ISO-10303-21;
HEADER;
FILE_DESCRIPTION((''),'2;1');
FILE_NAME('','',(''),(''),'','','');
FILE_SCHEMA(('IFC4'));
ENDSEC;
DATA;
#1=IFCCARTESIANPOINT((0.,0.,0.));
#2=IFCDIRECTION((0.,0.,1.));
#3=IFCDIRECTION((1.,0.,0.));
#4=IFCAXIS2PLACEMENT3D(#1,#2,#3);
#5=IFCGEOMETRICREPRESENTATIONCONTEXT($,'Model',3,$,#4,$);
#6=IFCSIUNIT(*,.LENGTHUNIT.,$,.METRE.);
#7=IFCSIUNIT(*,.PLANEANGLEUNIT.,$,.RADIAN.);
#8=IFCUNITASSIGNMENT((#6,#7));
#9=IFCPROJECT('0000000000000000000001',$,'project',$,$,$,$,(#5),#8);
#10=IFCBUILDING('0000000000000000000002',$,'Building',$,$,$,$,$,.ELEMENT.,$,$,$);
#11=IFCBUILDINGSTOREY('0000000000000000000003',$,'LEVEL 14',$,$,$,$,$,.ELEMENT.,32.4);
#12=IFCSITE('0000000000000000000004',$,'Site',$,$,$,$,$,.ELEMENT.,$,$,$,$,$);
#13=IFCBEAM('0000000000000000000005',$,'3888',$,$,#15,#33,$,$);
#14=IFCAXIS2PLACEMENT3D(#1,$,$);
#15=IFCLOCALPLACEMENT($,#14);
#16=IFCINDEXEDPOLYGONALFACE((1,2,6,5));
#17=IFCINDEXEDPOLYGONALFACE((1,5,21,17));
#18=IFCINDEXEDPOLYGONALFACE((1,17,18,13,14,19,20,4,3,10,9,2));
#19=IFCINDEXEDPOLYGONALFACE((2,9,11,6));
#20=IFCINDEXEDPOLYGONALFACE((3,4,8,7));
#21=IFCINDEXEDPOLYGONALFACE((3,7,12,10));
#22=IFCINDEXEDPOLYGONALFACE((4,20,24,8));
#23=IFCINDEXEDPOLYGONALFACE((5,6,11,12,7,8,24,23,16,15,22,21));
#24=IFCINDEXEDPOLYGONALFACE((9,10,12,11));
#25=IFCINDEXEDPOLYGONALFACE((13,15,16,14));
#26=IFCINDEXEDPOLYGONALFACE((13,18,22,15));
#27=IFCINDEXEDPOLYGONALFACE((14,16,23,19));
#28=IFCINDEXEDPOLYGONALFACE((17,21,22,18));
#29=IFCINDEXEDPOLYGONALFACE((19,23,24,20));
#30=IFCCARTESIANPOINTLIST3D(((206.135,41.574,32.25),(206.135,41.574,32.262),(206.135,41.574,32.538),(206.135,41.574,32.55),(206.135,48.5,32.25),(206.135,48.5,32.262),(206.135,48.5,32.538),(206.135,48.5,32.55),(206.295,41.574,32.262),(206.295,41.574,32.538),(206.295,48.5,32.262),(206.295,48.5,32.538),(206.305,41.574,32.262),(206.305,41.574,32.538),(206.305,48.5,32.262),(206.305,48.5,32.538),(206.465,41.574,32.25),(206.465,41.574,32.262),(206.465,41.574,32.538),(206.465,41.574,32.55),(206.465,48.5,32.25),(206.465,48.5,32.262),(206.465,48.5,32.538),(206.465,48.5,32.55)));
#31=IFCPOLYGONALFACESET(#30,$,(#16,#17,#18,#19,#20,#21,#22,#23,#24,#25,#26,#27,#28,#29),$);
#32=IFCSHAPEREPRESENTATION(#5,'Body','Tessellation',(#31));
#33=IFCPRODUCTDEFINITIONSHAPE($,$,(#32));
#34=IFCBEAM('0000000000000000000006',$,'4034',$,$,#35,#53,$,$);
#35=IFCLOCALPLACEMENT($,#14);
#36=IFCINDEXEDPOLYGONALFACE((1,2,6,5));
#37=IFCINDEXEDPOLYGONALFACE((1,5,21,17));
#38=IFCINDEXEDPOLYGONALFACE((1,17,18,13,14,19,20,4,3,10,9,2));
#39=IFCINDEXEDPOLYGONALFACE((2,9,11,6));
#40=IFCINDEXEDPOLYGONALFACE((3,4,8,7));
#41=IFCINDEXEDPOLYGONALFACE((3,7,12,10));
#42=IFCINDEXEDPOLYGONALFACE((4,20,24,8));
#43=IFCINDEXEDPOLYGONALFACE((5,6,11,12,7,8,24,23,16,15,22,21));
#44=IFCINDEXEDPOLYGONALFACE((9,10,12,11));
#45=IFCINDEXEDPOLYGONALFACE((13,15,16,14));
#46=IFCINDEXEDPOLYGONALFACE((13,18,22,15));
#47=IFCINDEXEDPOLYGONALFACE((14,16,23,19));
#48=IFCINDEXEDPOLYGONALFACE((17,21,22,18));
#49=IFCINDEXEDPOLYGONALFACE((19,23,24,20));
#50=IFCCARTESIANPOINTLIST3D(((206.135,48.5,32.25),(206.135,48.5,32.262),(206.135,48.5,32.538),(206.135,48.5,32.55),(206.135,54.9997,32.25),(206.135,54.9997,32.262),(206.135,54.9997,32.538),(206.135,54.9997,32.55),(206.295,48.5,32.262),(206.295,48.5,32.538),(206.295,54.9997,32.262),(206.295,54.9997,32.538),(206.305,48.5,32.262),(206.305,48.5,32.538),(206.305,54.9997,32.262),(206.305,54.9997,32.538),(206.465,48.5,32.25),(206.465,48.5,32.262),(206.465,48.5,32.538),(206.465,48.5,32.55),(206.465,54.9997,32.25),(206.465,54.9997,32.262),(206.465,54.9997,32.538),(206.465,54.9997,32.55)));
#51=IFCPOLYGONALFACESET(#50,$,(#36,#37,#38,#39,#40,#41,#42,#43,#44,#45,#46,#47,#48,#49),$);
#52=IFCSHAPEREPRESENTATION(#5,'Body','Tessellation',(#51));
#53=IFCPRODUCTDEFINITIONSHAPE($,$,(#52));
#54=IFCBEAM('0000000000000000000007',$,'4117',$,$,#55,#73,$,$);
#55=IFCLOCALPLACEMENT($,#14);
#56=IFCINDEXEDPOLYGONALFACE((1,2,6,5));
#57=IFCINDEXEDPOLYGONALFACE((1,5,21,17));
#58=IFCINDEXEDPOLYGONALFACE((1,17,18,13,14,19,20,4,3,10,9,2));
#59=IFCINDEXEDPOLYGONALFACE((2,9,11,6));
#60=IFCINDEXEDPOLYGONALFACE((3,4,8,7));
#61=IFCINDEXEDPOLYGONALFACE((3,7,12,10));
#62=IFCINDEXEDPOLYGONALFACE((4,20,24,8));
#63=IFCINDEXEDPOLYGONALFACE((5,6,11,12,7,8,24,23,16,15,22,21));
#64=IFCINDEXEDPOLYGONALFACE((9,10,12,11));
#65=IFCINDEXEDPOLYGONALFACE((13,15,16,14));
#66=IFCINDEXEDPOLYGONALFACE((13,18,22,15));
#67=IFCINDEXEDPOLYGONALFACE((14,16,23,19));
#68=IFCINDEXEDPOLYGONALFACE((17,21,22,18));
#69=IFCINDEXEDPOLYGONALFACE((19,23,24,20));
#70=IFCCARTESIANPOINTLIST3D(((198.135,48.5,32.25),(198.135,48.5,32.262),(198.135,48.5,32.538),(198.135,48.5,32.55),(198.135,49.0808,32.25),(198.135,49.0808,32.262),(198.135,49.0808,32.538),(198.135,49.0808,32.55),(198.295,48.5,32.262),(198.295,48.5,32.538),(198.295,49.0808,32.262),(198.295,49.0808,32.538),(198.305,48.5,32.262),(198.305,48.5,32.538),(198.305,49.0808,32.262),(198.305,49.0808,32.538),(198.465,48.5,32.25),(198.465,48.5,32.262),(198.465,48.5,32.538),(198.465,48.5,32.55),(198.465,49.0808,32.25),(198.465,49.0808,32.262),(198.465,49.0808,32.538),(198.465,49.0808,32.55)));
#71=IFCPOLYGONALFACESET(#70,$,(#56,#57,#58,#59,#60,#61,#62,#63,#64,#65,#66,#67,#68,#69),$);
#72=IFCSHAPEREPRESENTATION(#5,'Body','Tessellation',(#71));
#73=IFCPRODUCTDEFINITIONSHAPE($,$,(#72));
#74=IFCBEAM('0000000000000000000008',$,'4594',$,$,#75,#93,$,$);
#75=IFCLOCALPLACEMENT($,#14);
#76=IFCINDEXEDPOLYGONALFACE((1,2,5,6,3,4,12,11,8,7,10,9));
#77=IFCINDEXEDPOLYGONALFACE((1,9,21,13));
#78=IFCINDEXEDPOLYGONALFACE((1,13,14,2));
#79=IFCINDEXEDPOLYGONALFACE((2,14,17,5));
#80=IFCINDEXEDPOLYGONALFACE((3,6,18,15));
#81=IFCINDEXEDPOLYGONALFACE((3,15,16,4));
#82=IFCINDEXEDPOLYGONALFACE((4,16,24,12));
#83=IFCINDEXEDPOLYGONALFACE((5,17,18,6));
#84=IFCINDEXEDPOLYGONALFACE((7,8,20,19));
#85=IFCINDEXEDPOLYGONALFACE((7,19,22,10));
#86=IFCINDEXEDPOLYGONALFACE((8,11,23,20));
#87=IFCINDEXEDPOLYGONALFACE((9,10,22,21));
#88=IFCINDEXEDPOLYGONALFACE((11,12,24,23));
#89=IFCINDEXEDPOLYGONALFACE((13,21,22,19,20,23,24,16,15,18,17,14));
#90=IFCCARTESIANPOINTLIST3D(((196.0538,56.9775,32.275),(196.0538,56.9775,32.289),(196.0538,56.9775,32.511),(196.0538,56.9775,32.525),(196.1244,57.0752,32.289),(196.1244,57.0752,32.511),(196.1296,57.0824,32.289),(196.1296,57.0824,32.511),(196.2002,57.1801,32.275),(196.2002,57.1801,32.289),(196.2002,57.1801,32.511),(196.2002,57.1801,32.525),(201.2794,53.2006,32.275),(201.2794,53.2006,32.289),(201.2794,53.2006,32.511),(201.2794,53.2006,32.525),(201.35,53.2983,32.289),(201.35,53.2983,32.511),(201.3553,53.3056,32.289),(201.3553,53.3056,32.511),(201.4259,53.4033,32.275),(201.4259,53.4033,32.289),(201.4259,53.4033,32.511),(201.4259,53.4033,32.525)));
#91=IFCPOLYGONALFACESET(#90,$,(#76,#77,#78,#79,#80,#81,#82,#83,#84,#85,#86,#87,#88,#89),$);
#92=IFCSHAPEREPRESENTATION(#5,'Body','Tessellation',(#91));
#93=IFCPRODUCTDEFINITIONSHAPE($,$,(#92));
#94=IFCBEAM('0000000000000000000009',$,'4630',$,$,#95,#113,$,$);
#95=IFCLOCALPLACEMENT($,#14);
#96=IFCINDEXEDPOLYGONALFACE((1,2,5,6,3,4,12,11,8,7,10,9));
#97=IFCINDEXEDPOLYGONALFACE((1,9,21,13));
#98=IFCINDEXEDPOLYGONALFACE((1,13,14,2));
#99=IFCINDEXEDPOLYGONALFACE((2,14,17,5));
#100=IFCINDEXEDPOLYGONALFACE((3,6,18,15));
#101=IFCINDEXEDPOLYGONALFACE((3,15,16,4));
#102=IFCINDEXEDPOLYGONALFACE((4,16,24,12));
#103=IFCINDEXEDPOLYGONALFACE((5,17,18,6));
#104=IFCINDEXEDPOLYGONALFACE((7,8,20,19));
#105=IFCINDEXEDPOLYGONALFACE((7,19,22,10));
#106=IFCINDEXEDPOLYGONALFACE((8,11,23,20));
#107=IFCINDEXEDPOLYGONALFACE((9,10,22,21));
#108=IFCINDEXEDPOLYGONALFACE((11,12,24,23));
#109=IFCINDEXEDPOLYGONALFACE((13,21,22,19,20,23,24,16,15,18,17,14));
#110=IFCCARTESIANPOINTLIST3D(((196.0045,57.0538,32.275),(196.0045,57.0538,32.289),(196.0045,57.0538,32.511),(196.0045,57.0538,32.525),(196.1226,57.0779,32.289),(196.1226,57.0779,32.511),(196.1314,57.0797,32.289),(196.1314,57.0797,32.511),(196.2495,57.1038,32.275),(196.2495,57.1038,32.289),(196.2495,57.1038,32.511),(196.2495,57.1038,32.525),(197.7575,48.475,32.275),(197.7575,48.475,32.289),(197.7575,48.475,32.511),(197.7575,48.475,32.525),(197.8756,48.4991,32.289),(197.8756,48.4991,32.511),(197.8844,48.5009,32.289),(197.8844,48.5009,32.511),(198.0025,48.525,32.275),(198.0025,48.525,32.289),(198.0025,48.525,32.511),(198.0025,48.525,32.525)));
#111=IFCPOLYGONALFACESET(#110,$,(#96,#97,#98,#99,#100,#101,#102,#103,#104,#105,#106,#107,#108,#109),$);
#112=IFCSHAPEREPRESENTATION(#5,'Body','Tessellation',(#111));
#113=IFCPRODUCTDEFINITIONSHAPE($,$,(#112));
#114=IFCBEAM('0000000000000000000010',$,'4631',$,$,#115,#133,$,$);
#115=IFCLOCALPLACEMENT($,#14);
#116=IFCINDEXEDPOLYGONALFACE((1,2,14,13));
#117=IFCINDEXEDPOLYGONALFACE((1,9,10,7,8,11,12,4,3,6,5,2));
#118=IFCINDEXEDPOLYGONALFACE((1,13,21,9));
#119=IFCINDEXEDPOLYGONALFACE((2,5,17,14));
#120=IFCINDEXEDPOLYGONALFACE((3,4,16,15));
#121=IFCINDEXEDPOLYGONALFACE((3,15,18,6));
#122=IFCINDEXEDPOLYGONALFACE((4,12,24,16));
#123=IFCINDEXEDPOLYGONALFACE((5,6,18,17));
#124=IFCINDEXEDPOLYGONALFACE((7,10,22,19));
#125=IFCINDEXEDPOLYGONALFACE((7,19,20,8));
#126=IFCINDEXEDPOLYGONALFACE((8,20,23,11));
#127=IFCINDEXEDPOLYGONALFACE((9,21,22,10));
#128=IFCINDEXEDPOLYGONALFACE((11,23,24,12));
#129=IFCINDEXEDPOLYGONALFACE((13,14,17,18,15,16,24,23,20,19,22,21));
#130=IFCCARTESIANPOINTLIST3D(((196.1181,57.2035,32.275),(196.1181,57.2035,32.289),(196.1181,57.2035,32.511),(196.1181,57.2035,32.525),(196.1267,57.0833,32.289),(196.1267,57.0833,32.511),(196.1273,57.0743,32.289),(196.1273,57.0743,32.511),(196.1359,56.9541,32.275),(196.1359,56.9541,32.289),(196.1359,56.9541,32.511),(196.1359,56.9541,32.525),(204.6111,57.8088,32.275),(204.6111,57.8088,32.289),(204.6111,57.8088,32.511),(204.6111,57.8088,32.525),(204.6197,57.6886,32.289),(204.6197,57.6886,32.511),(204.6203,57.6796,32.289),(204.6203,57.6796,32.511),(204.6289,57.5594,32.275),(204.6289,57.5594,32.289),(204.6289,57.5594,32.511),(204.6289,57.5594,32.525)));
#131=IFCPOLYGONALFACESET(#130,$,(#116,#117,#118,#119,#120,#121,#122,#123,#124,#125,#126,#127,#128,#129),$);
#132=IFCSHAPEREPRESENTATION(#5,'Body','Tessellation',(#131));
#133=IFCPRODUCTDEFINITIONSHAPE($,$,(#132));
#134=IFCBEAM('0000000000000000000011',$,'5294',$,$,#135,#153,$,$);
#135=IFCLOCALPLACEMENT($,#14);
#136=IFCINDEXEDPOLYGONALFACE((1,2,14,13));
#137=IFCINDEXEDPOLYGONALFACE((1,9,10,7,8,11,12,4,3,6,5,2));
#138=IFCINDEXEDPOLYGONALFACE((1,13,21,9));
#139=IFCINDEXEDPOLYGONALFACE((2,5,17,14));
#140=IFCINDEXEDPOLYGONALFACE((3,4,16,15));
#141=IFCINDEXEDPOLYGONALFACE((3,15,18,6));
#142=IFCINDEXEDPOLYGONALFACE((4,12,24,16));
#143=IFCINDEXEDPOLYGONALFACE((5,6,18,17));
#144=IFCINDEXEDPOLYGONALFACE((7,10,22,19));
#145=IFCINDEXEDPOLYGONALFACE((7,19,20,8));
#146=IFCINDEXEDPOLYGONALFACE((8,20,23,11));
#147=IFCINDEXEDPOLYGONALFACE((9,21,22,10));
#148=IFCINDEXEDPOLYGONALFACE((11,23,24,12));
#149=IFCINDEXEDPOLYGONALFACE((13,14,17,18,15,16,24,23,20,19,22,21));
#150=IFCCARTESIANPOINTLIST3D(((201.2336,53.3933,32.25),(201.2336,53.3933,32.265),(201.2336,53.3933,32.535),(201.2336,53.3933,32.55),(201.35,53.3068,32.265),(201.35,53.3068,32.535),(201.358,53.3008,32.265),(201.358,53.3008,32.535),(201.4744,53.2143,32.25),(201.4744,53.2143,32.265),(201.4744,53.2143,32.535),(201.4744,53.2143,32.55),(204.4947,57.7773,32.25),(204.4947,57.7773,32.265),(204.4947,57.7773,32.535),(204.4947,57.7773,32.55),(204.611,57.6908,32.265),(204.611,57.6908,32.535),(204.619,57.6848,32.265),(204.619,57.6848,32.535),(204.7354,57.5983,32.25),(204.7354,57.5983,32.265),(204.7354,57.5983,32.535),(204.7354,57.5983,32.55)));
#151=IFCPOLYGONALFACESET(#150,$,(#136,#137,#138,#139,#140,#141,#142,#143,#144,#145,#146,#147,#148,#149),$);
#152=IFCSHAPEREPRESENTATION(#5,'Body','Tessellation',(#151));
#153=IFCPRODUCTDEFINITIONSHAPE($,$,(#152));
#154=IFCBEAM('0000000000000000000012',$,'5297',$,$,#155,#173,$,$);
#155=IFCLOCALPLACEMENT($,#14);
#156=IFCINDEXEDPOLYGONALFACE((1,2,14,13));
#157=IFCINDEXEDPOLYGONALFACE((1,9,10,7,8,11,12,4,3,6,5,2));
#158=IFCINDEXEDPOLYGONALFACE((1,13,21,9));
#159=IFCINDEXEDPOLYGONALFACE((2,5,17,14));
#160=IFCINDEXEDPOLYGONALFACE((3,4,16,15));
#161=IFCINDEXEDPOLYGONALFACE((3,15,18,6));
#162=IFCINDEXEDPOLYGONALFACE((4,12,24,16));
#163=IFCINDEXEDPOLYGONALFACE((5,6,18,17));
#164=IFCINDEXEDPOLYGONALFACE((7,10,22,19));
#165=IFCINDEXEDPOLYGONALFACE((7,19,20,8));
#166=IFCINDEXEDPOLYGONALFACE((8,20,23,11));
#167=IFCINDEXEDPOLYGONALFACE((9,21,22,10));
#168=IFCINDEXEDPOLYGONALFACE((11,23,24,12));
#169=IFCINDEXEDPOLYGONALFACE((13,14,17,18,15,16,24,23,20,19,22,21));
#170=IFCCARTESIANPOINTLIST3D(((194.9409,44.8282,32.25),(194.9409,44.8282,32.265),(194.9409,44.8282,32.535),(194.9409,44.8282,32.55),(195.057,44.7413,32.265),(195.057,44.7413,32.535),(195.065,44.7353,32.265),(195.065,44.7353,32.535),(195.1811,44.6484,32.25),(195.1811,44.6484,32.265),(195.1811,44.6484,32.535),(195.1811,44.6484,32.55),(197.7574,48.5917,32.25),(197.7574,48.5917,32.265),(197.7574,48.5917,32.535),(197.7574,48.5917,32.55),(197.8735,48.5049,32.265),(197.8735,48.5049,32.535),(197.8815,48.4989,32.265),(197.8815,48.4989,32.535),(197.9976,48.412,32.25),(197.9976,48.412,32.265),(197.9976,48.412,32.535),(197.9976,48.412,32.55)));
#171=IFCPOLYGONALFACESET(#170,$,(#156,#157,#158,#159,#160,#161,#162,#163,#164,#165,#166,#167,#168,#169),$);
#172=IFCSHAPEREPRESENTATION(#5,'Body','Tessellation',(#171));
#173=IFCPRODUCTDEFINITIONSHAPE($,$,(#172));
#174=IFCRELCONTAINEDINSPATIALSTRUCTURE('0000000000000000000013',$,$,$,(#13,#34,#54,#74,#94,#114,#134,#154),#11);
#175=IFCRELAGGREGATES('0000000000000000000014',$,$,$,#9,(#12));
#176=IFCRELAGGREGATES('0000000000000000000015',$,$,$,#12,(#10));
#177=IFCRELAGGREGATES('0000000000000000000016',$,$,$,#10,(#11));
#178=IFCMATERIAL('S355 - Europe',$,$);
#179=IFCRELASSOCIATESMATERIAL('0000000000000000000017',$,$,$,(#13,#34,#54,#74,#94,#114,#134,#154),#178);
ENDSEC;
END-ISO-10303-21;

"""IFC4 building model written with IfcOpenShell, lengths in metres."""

from ifc_helpers import new_model, si_unit, frame, origin_with_axes, origin_2d_with_axis, place, context, project, spatial, i_section, extrude, material, material_profile, profile_set, profile_usage, element, save


model = new_model("IFC4")

# Units and contexts
model_context = context("Model", 3, world=origin_with_axes())
ifc_project = project(units=[si_unit("LENGTHUNIT", "METRE"), si_unit("PLANEANGLEUNIT", "RADIAN")], contexts=[model_context])

# Site, building, storey
site = spatial("IfcSite", under=ifc_project, Name="Site", CompositionType="ELEMENT")
building = spatial("IfcBuilding", under=site, Name="Building", CompositionType="ELEMENT")
storey = spatial("IfcBuildingStorey", under=building, Name="LEVEL 14", CompositionType="ELEMENT", Elevation=32.4)

# Shared definitions
ifc_material = material(Name="S355 - Europe")

# Beams
ifc_material_profile_1 = material_profile(ifc_material, i_section(OverallWidth=0.33, OverallDepth=0.3, WebThickness=0.01, FlangeThickness=0.012, at=origin_2d_with_axis()))
ifc_profile_set_1 = profile_set([ifc_material_profile_1])
ifc_profile_usage_1 = profile_usage(ifc_profile_set_1, cardinal=10)
beam_1_placement = place(None, frame((206.3, 48.5, 32.4), z_axis=(0.0, -1.0, 0.0), x_axis=(1.0, 0.0, 0.0)))
element("IfcBeam", 1, at=beam_1_placement, inside=storey, material=ifc_profile_usage_1, Name="3888", context=model_context, shape_type="SweptSolid", body=[
    extrude(i_section(OverallWidth=0.33, OverallDepth=0.3, WebThickness=0.01, FlangeThickness=0.012, at=origin_2d_with_axis()), origin_with_axes(), (0.0, 0.0, 1.0), 6.926),
])
ifc_material_profile_2 = material_profile(ifc_material, i_section(OverallWidth=0.33, OverallDepth=0.3, WebThickness=0.01, FlangeThickness=0.012, at=origin_2d_with_axis()))
ifc_profile_set_2 = profile_set([ifc_material_profile_2])
ifc_profile_usage_2 = profile_usage(ifc_profile_set_2, cardinal=10)
beam_2_placement = place(None, frame((206.3, 54.9997, 32.4), z_axis=(0.0, -1.0, 0.0), x_axis=(1.0, 0.0, 0.0)))
element("IfcBeam", 2, at=beam_2_placement, inside=storey, material=ifc_profile_usage_2, Name="4034", context=model_context, shape_type="SweptSolid", body=[
    extrude(i_section(OverallWidth=0.33, OverallDepth=0.3, WebThickness=0.01, FlangeThickness=0.012, at=origin_2d_with_axis()), origin_with_axes(), (0.0, 0.0, 1.0), 6.4997),
])
ifc_material_profile_3 = material_profile(ifc_material, i_section(OverallWidth=0.33, OverallDepth=0.3, WebThickness=0.01, FlangeThickness=0.012, at=origin_2d_with_axis()))
ifc_profile_set_3 = profile_set([ifc_material_profile_3])
ifc_profile_usage_3 = profile_usage(ifc_profile_set_3, cardinal=10)
beam_3_placement = place(None, frame((198.3, 48.5, 32.4), z_axis=(0.0, 1.0, 0.0), x_axis=(-1.0, 0.0, 0.0)))
element("IfcBeam", 3, at=beam_3_placement, inside=storey, material=ifc_profile_usage_3, Name="4117", context=model_context, shape_type="SweptSolid", body=[
    extrude(i_section(OverallWidth=0.33, OverallDepth=0.3, WebThickness=0.01, FlangeThickness=0.012, at=origin_2d_with_axis()), origin_with_axes(), (0.0, 0.0, 1.0), 0.5808),
])
ifc_material_profile_4 = material_profile(ifc_material, i_section(OverallWidth=0.25, OverallDepth=0.25, WebThickness=0.009, FlangeThickness=0.014, at=origin_2d_with_axis()))
ifc_profile_set_4 = profile_set([ifc_material_profile_4])
ifc_profile_usage_4 = profile_usage(ifc_profile_set_4, cardinal=10)
beam_4_placement = place(None, frame((196.127, 57.0788, 32.4), z_axis=(0.810475, -0.585773, 0.0), x_axis=(0.585773, 0.810475, 0.0)))
element("IfcBeam", 4, at=beam_4_placement, inside=storey, material=ifc_profile_usage_4, Name="4594", context=model_context, shape_type="SweptSolid", body=[
    extrude(i_section(OverallWidth=0.25, OverallDepth=0.25, WebThickness=0.009, FlangeThickness=0.014, at=origin_2d_with_axis()), origin_with_axes(), (0.0, 0.0, 1.0), 6.4476),
])
ifc_material_profile_5 = material_profile(ifc_material, i_section(OverallWidth=0.25, OverallDepth=0.25, WebThickness=0.009, FlangeThickness=0.014, at=origin_2d_with_axis()))
ifc_profile_set_5 = profile_set([ifc_material_profile_5])
ifc_profile_usage_5 = profile_usage(ifc_profile_set_5, cardinal=10)
beam_5_placement = place(None, frame((197.88, 48.5, 32.4), z_axis=(-0.200204, 0.979754, 0.0), x_axis=(-0.979754, -0.200204, 0.0)))
element("IfcBeam", 5, at=beam_5_placement, inside=storey, material=ifc_profile_usage_5, Name="4630", context=model_context, shape_type="SweptSolid", body=[
    extrude(i_section(OverallWidth=0.25, OverallDepth=0.25, WebThickness=0.009, FlangeThickness=0.014, at=origin_2d_with_axis()), origin_with_axes(), (0.0, 0.0, 1.0), 8.7561),
])
ifc_material_profile_6 = material_profile(ifc_material, i_section(OverallWidth=0.25, OverallDepth=0.25, WebThickness=0.009, FlangeThickness=0.014, at=origin_2d_with_axis()))
ifc_profile_set_6 = profile_set([ifc_material_profile_6])
ifc_profile_usage_6 = profile_usage(ifc_profile_set_6, cardinal=10)
beam_6_placement = place(None, frame((196.127, 57.0788, 32.4), z_axis=(0.99747, 0.07109, 0.0), x_axis=(-0.07109, 0.99747, 0.0)))
element("IfcBeam", 6, at=beam_6_placement, inside=storey, material=ifc_profile_usage_6, Name="4631", context=model_context, shape_type="SweptSolid", body=[
    extrude(i_section(OverallWidth=0.25, OverallDepth=0.25, WebThickness=0.009, FlangeThickness=0.014, at=origin_2d_with_axis()), origin_with_axes(), (0.0, 0.0, 1.0), 8.5145),
])
ifc_material_profile_7 = material_profile(ifc_material, i_section(OverallWidth=0.3, OverallDepth=0.3, WebThickness=0.01, FlangeThickness=0.015, at=origin_2d_with_axis()))
ifc_profile_set_7 = profile_set([ifc_material_profile_7])
ifc_profile_usage_7 = profile_usage(ifc_profile_set_7, cardinal=10)
beam_7_placement = place(None, frame((201.354, 53.3038, 32.4), z_axis=(0.596835, 0.802364, 0.0), x_axis=(-0.801686, 0.597746, 0.0)))
element("IfcBeam", 7, at=beam_7_placement, inside=storey, material=ifc_profile_usage_7, Name="5294", context=model_context, shape_type="SweptSolid", body=[
    extrude(i_section(OverallWidth=0.3, OverallDepth=0.3, WebThickness=0.01, FlangeThickness=0.015, at=origin_2d_with_axis()), origin_with_axes(), (0.0, 0.0, 1.0), 5.4639),
])
ifc_material_profile_8 = material_profile(ifc_material, i_section(OverallWidth=0.3, OverallDepth=0.3, WebThickness=0.01, FlangeThickness=0.015, at=origin_2d_with_axis()))
ifc_profile_set_8 = profile_set([ifc_material_profile_8])
ifc_profile_usage_8 = profile_usage(ifc_profile_set_8, cardinal=10)
beam_8_placement = place(None, frame((195.061, 44.7383, 32.4), z_axis=(0.599157, 0.800631, 0.0), x_axis=(-0.800232, 0.59969, 0.0)))
element("IfcBeam", 8, at=beam_8_placement, inside=storey, material=ifc_profile_usage_8, Name="5297", context=model_context, shape_type="SweptSolid", body=[
    extrude(i_section(OverallWidth=0.3, OverallDepth=0.3, WebThickness=0.01, FlangeThickness=0.015, at=origin_2d_with_axis()), origin_with_axes(), (0.0, 0.0, 1.0), 4.7008),
])

save(model, "model.ifc")
